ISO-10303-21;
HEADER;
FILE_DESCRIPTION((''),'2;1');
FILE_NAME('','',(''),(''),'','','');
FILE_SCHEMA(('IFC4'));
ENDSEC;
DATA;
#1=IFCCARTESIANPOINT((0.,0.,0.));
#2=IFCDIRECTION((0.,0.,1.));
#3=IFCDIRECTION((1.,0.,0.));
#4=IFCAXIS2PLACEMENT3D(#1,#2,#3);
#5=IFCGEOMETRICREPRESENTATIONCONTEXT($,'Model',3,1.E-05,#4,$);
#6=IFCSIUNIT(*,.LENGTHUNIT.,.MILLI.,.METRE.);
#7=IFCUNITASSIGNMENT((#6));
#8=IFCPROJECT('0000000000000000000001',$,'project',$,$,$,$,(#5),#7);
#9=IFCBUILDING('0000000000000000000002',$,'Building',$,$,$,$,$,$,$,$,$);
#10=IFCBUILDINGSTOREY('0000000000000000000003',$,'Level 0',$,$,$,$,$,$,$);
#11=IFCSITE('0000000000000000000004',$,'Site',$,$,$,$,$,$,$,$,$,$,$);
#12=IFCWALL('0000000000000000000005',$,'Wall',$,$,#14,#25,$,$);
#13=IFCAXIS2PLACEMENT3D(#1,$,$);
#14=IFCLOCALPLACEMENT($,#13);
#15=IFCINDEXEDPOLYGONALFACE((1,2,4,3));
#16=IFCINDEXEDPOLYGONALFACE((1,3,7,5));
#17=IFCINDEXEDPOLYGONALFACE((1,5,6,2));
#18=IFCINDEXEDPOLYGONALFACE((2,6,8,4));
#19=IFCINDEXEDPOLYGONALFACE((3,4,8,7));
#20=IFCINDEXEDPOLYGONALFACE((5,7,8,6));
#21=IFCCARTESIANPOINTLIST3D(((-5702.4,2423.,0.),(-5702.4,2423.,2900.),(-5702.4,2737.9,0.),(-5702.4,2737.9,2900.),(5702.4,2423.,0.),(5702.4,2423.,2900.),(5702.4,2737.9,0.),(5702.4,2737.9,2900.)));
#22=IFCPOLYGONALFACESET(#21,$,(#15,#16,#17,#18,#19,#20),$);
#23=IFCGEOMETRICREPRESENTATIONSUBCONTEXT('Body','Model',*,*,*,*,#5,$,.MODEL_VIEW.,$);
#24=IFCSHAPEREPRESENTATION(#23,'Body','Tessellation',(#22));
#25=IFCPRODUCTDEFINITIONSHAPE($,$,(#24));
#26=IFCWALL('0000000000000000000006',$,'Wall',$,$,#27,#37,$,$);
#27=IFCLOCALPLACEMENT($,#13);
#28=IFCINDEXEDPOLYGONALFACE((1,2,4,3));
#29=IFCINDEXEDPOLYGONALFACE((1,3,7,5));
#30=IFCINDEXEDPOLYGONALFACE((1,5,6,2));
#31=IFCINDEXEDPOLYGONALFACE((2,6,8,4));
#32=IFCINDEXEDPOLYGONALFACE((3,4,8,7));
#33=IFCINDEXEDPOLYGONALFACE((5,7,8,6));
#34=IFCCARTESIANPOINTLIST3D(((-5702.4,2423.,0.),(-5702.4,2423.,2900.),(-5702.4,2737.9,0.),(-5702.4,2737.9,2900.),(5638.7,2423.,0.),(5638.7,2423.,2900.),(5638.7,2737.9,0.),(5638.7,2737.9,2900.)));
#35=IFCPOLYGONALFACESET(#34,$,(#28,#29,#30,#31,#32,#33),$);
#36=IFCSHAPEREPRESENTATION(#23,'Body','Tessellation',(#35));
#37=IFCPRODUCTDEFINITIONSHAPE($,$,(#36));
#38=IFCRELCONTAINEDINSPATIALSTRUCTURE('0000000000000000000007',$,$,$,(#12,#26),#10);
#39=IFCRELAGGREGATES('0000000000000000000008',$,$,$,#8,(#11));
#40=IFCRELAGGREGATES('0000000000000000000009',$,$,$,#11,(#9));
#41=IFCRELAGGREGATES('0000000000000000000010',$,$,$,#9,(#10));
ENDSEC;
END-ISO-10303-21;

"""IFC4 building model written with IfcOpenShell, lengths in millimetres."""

from ifc_helpers import new_model, si_unit, frame, origin_with_axes, place, context, subcontext, project, spatial, indexed_curve, outline, extrude, element, save


model = new_model("IFC4")

# Units and contexts
model_context = context("Model", 3, precision=1e-05, world=origin_with_axes())
body_context = subcontext(model_context, "Body", "Model", "MODEL_VIEW")
ifc_project = project(units=[si_unit("LENGTHUNIT", "METRE", prefix="MILLI")], contexts=[model_context])

# Site, building, storey
site = spatial("IfcSite", under=ifc_project, Name="Site")
building = spatial("IfcBuilding", under=site, Name="Building")
storey = spatial("IfcBuildingStorey", under=building, Name="Level 0")

# Walls
wall_1_placement = place(None, frame((-5702.4, 2423.0, 0.0), z_axis=(0.0, 0.0, 1.0), x_axis=(1.0, 0.0, 0.0)))
element("IfcWall", 1, at=wall_1_placement, inside=storey, Name="Wall", context=body_context, shape_type="SweptSolid", body=[
    extrude(outline(indexed_curve([(0.0, 0.0), (0.0, 314.9), (11404.8, 314.9), (11404.8, 0.0), (0.0, 0.0)], self_intersect=False)), origin_with_axes(), (0.0, 0.0, 1.0), 2900.0),
])
wall_2_placement = place(None, frame((-5702.4, 2423.0, 0.0), z_axis=(0.0, 0.0, 1.0), x_axis=(1.0, 0.0, 0.0)))
element("IfcWall", 2, at=wall_2_placement, inside=storey, Name="Wall", context=body_context, shape_type="SweptSolid", body=[
    extrude(outline(indexed_curve([(0.0, 0.0), (0.0, 314.9), (11341.1, 314.9), (11341.1, 0.0), (0.0, 0.0)], self_intersect=False)), origin_with_axes(), (0.0, 0.0, 1.0), 2900.0),
])

save(model, "model.ifc")
